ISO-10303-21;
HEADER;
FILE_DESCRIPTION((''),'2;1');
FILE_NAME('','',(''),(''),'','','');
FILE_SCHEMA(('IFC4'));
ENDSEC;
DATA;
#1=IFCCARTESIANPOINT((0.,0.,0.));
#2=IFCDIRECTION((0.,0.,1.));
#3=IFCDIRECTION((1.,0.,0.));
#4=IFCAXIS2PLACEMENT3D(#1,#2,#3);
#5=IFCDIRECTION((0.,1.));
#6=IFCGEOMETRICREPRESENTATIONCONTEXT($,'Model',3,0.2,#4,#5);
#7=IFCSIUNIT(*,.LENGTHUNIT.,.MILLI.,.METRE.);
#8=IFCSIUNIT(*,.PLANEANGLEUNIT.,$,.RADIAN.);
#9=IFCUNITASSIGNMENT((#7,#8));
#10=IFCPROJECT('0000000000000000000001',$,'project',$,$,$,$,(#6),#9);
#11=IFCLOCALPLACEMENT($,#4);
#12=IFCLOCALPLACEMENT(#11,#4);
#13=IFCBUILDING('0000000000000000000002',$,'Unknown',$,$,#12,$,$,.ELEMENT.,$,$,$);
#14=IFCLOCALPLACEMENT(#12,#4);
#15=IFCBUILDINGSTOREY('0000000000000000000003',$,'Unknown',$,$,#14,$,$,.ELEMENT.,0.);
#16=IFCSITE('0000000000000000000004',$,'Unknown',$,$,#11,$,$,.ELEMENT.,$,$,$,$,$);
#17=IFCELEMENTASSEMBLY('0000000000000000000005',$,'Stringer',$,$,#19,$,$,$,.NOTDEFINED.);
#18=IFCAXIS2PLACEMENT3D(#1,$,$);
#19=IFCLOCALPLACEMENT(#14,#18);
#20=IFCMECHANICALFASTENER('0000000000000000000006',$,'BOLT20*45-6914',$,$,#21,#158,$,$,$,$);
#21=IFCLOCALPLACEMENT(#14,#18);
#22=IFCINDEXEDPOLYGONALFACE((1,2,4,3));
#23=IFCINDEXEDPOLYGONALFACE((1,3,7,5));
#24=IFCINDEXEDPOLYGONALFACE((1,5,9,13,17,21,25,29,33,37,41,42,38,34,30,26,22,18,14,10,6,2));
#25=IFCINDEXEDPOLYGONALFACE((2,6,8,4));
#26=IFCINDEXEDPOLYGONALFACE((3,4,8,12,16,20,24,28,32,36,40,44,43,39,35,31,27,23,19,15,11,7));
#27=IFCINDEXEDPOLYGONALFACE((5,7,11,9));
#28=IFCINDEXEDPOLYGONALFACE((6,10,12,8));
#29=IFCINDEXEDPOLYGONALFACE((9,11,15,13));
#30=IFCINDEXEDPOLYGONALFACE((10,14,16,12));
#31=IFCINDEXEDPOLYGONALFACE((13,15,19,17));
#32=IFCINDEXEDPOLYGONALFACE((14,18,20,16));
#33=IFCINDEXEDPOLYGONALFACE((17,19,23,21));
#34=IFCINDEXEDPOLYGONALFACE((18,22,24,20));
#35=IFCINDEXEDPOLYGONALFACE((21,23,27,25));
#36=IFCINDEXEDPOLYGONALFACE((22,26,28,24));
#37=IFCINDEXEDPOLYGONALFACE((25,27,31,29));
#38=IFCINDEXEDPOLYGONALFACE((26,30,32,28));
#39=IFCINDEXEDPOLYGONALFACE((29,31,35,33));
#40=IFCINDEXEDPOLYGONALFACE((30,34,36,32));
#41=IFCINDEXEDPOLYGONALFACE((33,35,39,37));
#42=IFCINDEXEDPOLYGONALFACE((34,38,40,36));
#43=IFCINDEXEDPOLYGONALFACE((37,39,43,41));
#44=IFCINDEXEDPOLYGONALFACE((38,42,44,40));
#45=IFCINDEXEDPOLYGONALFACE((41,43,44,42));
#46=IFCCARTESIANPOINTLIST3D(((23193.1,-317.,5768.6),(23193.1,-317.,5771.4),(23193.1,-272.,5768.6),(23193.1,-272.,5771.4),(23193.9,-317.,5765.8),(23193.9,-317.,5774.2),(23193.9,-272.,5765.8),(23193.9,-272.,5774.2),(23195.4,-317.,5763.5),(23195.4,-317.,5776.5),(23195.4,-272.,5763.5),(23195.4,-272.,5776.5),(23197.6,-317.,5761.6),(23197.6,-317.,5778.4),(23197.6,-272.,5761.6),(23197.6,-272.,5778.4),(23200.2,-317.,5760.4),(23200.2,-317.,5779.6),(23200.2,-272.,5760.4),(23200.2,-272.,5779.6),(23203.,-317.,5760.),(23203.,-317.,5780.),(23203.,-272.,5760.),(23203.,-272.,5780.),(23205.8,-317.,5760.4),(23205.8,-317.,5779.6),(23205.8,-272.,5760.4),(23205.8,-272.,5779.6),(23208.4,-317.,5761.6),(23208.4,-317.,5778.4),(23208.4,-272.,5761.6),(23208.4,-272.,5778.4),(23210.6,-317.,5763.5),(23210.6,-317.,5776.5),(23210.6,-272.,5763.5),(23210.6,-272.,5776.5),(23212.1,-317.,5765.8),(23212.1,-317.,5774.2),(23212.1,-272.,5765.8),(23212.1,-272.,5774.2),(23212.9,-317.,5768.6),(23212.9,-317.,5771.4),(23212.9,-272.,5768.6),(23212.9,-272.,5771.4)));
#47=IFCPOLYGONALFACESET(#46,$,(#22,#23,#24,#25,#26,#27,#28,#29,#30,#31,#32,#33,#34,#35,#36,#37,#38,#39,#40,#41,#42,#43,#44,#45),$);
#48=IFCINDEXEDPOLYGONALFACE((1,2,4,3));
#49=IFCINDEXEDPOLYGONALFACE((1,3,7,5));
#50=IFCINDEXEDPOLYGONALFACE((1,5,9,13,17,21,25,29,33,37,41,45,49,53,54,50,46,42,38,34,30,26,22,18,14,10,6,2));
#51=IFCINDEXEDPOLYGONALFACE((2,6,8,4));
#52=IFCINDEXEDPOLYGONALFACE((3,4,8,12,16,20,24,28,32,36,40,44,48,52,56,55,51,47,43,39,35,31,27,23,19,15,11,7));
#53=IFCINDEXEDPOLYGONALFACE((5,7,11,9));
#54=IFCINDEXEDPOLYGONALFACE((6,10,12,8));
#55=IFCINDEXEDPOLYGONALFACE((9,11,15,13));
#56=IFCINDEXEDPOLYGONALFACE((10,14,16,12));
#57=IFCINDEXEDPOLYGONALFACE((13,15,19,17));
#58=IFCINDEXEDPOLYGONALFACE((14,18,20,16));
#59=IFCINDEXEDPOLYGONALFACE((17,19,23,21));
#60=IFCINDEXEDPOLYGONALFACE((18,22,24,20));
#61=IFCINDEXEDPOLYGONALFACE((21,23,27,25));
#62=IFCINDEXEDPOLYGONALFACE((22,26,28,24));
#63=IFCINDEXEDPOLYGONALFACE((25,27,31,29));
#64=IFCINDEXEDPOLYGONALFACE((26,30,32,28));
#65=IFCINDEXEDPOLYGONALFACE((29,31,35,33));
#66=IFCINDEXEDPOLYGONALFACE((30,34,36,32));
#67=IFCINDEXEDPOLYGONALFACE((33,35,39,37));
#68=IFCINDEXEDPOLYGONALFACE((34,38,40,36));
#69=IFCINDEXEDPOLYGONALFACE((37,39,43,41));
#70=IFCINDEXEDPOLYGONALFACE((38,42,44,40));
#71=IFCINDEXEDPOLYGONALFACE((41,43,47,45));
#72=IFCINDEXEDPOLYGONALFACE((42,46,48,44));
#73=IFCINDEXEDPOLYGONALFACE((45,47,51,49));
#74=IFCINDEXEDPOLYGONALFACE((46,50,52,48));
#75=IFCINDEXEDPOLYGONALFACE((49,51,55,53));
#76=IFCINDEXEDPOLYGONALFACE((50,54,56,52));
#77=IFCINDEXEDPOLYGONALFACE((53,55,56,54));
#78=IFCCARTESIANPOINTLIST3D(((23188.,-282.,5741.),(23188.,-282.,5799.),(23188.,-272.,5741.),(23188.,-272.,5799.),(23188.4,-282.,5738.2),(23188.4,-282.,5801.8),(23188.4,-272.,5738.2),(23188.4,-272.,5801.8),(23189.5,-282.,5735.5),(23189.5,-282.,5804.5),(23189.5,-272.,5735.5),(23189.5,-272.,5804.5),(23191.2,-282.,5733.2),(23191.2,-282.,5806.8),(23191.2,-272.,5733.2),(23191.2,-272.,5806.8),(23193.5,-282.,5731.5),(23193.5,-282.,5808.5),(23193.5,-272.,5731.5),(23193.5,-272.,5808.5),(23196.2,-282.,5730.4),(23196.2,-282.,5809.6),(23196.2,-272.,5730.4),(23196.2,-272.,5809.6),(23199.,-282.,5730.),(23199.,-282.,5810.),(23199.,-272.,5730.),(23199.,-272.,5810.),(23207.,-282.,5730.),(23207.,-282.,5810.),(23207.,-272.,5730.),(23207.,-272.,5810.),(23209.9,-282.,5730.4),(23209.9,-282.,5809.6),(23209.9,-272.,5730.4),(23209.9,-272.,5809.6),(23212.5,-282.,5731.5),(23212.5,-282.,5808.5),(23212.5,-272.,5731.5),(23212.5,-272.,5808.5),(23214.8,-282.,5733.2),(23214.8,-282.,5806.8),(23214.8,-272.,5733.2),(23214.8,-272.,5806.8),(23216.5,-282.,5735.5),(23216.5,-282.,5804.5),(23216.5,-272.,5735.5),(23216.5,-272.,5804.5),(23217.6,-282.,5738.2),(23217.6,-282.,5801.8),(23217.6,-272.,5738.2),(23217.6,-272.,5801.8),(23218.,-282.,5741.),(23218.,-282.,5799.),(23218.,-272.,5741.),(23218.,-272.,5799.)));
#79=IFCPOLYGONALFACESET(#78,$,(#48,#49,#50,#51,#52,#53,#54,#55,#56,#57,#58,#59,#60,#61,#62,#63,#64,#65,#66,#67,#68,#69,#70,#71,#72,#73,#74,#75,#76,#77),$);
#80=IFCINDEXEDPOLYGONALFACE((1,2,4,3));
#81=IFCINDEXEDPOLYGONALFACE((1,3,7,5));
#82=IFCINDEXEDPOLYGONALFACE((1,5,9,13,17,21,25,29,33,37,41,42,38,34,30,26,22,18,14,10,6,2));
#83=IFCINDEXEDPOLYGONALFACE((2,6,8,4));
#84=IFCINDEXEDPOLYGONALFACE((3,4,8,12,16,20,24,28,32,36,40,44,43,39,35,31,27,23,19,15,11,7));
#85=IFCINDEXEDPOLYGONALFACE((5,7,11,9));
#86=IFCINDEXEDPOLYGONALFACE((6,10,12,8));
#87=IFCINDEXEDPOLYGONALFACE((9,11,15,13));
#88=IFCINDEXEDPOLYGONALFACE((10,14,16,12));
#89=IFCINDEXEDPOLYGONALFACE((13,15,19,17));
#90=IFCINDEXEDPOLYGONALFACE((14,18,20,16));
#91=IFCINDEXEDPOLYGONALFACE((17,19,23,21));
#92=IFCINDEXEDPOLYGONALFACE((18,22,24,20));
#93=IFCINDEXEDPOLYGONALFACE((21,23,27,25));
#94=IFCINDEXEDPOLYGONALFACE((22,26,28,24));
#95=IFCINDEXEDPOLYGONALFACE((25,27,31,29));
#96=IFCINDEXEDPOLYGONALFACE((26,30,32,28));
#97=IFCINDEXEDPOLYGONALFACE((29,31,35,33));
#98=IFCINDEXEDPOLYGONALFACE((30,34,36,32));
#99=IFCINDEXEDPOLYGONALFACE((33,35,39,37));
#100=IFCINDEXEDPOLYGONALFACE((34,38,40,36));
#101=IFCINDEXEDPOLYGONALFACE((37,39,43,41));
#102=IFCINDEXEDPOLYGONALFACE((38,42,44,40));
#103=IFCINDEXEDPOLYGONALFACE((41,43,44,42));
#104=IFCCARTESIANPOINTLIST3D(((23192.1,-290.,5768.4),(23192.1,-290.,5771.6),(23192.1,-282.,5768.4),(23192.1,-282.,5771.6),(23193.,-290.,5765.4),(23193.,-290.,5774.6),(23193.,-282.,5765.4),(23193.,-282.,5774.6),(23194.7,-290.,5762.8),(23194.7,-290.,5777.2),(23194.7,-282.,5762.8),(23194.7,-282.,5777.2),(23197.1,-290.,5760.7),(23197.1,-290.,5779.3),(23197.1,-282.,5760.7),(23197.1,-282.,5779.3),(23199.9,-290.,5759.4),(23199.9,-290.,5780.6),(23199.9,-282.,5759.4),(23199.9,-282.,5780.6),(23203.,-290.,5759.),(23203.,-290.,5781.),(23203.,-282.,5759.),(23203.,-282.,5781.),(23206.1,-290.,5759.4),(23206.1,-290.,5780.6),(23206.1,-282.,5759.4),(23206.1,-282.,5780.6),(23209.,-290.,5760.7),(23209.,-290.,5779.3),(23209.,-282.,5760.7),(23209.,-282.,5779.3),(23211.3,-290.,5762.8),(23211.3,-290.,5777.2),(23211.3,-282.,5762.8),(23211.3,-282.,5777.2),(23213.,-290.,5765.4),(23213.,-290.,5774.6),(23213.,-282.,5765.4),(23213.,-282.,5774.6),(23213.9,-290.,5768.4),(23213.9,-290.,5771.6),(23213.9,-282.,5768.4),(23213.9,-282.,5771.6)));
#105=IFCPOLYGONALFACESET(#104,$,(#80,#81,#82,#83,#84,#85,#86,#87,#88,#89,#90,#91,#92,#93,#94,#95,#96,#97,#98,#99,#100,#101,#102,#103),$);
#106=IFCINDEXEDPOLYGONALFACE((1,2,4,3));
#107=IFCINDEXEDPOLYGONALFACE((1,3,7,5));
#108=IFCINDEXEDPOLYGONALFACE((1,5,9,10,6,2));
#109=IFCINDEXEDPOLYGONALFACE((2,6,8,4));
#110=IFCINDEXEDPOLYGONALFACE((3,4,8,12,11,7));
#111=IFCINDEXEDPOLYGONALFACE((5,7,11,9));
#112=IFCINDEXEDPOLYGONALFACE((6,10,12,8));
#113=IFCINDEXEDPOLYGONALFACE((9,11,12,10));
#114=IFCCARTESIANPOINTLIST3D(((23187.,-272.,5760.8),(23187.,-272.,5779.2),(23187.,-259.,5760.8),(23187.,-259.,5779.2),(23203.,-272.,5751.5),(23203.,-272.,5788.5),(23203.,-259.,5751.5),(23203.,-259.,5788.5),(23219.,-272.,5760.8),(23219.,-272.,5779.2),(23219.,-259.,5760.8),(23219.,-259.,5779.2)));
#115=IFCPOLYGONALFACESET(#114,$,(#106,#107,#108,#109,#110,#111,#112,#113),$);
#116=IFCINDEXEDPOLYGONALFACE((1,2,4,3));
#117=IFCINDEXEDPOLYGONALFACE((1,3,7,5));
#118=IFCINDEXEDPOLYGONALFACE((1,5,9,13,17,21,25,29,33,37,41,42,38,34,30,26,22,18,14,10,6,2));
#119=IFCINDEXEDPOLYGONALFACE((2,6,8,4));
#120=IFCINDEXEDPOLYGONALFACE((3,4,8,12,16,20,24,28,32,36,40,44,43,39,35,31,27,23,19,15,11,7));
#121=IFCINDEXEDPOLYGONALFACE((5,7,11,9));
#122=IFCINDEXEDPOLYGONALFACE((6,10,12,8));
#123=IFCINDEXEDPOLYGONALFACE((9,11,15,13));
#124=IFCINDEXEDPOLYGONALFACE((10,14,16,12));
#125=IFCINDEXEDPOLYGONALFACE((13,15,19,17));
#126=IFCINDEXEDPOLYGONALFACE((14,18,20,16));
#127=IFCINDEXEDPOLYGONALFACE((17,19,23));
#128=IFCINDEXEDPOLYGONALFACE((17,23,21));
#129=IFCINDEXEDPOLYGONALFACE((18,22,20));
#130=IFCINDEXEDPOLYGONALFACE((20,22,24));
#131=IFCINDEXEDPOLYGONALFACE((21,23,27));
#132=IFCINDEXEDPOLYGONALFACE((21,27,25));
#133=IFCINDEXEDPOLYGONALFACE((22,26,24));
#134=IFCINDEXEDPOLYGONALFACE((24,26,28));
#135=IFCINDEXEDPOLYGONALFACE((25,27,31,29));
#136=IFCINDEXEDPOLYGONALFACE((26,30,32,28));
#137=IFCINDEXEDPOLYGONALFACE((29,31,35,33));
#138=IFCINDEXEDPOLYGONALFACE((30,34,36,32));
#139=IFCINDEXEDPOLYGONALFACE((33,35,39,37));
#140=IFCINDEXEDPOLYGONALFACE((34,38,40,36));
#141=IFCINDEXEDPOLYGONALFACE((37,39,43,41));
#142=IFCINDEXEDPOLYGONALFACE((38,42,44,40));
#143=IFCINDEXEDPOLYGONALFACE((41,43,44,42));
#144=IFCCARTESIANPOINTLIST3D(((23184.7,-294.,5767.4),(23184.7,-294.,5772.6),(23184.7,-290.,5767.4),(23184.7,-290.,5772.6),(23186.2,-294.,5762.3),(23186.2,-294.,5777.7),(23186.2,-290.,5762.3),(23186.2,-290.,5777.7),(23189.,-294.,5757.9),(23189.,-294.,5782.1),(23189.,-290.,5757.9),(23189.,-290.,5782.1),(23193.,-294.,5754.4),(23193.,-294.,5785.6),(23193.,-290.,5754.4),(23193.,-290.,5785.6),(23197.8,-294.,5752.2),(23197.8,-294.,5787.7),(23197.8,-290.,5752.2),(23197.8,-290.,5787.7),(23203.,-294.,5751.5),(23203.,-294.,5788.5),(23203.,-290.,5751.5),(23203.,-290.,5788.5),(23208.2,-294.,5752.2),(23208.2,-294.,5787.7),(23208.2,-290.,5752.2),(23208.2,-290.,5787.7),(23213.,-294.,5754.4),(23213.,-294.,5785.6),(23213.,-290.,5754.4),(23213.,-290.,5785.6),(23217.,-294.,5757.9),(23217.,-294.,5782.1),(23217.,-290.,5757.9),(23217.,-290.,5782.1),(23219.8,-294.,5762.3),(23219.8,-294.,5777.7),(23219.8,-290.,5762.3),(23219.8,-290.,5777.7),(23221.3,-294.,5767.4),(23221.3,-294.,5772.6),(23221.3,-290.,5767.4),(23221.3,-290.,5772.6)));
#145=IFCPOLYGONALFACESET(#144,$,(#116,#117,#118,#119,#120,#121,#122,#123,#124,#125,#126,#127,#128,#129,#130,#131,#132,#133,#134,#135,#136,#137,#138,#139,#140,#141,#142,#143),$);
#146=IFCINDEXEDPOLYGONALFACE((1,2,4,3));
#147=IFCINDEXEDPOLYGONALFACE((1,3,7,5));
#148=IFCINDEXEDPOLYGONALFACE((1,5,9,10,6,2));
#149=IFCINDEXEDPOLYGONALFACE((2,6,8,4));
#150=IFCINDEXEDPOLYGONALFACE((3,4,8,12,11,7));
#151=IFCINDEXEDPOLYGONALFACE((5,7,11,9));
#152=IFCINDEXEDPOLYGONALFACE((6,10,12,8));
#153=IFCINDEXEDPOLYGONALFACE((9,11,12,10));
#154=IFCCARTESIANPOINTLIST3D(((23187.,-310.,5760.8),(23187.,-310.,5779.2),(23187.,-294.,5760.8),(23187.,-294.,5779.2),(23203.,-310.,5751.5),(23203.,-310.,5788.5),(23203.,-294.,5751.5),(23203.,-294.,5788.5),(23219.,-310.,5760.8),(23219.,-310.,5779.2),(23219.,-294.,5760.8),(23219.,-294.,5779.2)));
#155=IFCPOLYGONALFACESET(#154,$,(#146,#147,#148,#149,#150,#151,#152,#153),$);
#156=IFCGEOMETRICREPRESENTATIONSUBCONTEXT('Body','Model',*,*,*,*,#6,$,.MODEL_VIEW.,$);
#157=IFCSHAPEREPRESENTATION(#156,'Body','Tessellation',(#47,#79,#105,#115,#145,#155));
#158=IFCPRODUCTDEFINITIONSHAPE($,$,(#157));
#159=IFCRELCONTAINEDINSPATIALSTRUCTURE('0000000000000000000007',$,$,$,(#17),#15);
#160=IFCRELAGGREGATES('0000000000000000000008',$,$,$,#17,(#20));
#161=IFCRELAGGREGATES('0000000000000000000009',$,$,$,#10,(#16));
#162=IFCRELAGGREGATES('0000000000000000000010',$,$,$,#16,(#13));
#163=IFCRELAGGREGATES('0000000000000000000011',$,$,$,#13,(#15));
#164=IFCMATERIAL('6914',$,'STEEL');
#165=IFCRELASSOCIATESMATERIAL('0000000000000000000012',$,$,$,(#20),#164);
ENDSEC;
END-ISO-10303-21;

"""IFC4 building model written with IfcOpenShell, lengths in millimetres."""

from ifc_helpers import new_model, si_unit, direction, frame, origin_with_axes, place, context, subcontext, project, spatial, line, arc, indexed_curve, outline, extrude, source, transform, mapped, material, element, aggregate, save


model = new_model("IFC4")

# Units and contexts
model_context = context("Model", 3, precision=0.2, world=origin_with_axes(), true_north=direction((0.0, 1.0)))
body_context = subcontext(model_context, "Body", "Model", "MODEL_VIEW")
ifc_project = project(units=[si_unit("LENGTHUNIT", "METRE", prefix="MILLI"), si_unit("PLANEANGLEUNIT", "RADIAN")], contexts=[model_context])

# Site, building, storey
site_placement = place(None, origin_with_axes())
site = spatial("IfcSite", under=ifc_project, at=site_placement, Name="Unknown", CompositionType="ELEMENT")
building_placement = place(site_placement, origin_with_axes())
building = spatial("IfcBuilding", under=site, at=building_placement, Name="Unknown", CompositionType="ELEMENT")
storey_placement = place(building_placement, origin_with_axes())
storey = spatial("IfcBuildingStorey", under=building, at=storey_placement, Name="Unknown", CompositionType="ELEMENT", Elevation=0.0)

# Element assembly
assembly_1_placement = place(storey_placement, frame((23193.0, -780.0, 7430.0), z_axis=(0.0, -1.0, 0.000002), x_axis=(0.0, -0.000002, -1.0)))
assembly_1 = element("IfcElementAssembly", 1, at=assembly_1_placement, inside=storey, Name="Stringer", PredefinedType="NOTDEFINED")

# Mechanical fastener
ifc_material_1 = material(Name="6914", Category="STEEL")
shared_shape_1 = source(origin_with_axes(), body_context, "Body", "SweptSolid", [
    extrude(outline(indexed_curve([(10.0, 0.0), (0.0, 10.0), (-10.0, 0.0), (0.0, -10.0)], segments=[arc(1, 2, 3), arc(3, 4, 1)])), frame((0.0, 0.0, 10.0), z_axis=(0.0, -0.000002, -1.0), x_axis=(0.0, 1.0, 0.0)), (0.0, 0.0, 1.0), 45.0),
    extrude(outline(indexed_curve([(-29.0, 15.0), (29.0, 15.0), (29.0, 15.0), (36.8, 11.8), (40.0, 4.0), (40.0, -4.0), (36.8, -11.8), (29.0, -15.0), (-29.0, -15.0), (-30.0, -15.0), (-40.0, -4.0), (-40.0, 4.0), (-36.8, 11.8)], segments=[line(1, 2, 3), arc(3, 4, 5), line(5, 6), arc(6, 7, 8), line(8, 9), arc(9, 10, 11), line(11, 12), arc(12, 13, 1)])), frame((0.0, 0.0, 10.0), z_axis=(0.0, -0.000002, -1.0), x_axis=(0.0, 1.0, 0.0)), (0.0, 0.0, 1.0), 10.0),
    extrude(outline(indexed_curve([(11.0, 0.0), (0.0, 11.0), (-11.0, 0.0), (0.0, -11.0)], segments=[arc(1, 2, 3), arc(3, 4, 1)])), frame((0.0, 0.0, 0.0), z_axis=(0.0, -0.000002, -1.0), x_axis=(0.0, 1.0, 0.0)), (0.0, 0.0, 1.0), 8.0),
    extrude(outline(indexed_curve([(18.5, 0.0), (9.2, 16.0), (-9.2, 16.0), (-18.5, 0.0), (-9.2, -16.0), (9.2, -16.0)], segments=[line(1, 2, 3, 4, 5, 6, 1)])), frame((0.0, 0.0, 23.0), z_axis=(0.0, -0.000002, -1.0), x_axis=(0.0, 1.0, 0.0)), (0.0, 0.0, 1.0), 13.0),
    extrude(outline(indexed_curve([(18.5, 0.0), (0.0, 18.5), (-18.5, 0.0), (0.0, -18.5)], segments=[arc(1, 2, 3), arc(3, 4, 1)])), frame((0.0, 0.0, -8.0), z_axis=(0.0, -0.000002, -1.0), x_axis=(0.0, 1.0, 0.0)), (0.0, 0.0, 1.0), 4.0),
    extrude(outline(indexed_curve([(18.5, 0.0), (9.2, 16.0), (-9.2, 16.0), (-18.5, 0.0), (-9.2, -16.0), (9.2, -16.0)], segments=[line(1, 2, 3, 4, 5, 6, 1)])), frame((0.0, 0.0, -12.0), z_axis=(0.0, -0.000002, -1.0), x_axis=(0.0, 1.0, 0.0)), (0.0, 0.0, 1.0), 16.0),
])
mechanical_fastener_1_placement = place(assembly_1_placement, frame((1660.0, 10.0, -498.0), z_axis=(0.0, -0.000002, -1.0), x_axis=(0.0, -1.0, 0.000002)))
mechanical_fastener_1 = element("IfcMechanicalFastener", 2, at=mechanical_fastener_1_placement, material=ifc_material_1, Name="BOLT20*45-6914", context=body_context, shape_type="MappedRepresentation", body=[
    mapped(shared_shape_1, transform((0.0, 0.0, 0.0))),
])
aggregate(assembly_1, [mechanical_fastener_1])

save(model, "model.ifc")
